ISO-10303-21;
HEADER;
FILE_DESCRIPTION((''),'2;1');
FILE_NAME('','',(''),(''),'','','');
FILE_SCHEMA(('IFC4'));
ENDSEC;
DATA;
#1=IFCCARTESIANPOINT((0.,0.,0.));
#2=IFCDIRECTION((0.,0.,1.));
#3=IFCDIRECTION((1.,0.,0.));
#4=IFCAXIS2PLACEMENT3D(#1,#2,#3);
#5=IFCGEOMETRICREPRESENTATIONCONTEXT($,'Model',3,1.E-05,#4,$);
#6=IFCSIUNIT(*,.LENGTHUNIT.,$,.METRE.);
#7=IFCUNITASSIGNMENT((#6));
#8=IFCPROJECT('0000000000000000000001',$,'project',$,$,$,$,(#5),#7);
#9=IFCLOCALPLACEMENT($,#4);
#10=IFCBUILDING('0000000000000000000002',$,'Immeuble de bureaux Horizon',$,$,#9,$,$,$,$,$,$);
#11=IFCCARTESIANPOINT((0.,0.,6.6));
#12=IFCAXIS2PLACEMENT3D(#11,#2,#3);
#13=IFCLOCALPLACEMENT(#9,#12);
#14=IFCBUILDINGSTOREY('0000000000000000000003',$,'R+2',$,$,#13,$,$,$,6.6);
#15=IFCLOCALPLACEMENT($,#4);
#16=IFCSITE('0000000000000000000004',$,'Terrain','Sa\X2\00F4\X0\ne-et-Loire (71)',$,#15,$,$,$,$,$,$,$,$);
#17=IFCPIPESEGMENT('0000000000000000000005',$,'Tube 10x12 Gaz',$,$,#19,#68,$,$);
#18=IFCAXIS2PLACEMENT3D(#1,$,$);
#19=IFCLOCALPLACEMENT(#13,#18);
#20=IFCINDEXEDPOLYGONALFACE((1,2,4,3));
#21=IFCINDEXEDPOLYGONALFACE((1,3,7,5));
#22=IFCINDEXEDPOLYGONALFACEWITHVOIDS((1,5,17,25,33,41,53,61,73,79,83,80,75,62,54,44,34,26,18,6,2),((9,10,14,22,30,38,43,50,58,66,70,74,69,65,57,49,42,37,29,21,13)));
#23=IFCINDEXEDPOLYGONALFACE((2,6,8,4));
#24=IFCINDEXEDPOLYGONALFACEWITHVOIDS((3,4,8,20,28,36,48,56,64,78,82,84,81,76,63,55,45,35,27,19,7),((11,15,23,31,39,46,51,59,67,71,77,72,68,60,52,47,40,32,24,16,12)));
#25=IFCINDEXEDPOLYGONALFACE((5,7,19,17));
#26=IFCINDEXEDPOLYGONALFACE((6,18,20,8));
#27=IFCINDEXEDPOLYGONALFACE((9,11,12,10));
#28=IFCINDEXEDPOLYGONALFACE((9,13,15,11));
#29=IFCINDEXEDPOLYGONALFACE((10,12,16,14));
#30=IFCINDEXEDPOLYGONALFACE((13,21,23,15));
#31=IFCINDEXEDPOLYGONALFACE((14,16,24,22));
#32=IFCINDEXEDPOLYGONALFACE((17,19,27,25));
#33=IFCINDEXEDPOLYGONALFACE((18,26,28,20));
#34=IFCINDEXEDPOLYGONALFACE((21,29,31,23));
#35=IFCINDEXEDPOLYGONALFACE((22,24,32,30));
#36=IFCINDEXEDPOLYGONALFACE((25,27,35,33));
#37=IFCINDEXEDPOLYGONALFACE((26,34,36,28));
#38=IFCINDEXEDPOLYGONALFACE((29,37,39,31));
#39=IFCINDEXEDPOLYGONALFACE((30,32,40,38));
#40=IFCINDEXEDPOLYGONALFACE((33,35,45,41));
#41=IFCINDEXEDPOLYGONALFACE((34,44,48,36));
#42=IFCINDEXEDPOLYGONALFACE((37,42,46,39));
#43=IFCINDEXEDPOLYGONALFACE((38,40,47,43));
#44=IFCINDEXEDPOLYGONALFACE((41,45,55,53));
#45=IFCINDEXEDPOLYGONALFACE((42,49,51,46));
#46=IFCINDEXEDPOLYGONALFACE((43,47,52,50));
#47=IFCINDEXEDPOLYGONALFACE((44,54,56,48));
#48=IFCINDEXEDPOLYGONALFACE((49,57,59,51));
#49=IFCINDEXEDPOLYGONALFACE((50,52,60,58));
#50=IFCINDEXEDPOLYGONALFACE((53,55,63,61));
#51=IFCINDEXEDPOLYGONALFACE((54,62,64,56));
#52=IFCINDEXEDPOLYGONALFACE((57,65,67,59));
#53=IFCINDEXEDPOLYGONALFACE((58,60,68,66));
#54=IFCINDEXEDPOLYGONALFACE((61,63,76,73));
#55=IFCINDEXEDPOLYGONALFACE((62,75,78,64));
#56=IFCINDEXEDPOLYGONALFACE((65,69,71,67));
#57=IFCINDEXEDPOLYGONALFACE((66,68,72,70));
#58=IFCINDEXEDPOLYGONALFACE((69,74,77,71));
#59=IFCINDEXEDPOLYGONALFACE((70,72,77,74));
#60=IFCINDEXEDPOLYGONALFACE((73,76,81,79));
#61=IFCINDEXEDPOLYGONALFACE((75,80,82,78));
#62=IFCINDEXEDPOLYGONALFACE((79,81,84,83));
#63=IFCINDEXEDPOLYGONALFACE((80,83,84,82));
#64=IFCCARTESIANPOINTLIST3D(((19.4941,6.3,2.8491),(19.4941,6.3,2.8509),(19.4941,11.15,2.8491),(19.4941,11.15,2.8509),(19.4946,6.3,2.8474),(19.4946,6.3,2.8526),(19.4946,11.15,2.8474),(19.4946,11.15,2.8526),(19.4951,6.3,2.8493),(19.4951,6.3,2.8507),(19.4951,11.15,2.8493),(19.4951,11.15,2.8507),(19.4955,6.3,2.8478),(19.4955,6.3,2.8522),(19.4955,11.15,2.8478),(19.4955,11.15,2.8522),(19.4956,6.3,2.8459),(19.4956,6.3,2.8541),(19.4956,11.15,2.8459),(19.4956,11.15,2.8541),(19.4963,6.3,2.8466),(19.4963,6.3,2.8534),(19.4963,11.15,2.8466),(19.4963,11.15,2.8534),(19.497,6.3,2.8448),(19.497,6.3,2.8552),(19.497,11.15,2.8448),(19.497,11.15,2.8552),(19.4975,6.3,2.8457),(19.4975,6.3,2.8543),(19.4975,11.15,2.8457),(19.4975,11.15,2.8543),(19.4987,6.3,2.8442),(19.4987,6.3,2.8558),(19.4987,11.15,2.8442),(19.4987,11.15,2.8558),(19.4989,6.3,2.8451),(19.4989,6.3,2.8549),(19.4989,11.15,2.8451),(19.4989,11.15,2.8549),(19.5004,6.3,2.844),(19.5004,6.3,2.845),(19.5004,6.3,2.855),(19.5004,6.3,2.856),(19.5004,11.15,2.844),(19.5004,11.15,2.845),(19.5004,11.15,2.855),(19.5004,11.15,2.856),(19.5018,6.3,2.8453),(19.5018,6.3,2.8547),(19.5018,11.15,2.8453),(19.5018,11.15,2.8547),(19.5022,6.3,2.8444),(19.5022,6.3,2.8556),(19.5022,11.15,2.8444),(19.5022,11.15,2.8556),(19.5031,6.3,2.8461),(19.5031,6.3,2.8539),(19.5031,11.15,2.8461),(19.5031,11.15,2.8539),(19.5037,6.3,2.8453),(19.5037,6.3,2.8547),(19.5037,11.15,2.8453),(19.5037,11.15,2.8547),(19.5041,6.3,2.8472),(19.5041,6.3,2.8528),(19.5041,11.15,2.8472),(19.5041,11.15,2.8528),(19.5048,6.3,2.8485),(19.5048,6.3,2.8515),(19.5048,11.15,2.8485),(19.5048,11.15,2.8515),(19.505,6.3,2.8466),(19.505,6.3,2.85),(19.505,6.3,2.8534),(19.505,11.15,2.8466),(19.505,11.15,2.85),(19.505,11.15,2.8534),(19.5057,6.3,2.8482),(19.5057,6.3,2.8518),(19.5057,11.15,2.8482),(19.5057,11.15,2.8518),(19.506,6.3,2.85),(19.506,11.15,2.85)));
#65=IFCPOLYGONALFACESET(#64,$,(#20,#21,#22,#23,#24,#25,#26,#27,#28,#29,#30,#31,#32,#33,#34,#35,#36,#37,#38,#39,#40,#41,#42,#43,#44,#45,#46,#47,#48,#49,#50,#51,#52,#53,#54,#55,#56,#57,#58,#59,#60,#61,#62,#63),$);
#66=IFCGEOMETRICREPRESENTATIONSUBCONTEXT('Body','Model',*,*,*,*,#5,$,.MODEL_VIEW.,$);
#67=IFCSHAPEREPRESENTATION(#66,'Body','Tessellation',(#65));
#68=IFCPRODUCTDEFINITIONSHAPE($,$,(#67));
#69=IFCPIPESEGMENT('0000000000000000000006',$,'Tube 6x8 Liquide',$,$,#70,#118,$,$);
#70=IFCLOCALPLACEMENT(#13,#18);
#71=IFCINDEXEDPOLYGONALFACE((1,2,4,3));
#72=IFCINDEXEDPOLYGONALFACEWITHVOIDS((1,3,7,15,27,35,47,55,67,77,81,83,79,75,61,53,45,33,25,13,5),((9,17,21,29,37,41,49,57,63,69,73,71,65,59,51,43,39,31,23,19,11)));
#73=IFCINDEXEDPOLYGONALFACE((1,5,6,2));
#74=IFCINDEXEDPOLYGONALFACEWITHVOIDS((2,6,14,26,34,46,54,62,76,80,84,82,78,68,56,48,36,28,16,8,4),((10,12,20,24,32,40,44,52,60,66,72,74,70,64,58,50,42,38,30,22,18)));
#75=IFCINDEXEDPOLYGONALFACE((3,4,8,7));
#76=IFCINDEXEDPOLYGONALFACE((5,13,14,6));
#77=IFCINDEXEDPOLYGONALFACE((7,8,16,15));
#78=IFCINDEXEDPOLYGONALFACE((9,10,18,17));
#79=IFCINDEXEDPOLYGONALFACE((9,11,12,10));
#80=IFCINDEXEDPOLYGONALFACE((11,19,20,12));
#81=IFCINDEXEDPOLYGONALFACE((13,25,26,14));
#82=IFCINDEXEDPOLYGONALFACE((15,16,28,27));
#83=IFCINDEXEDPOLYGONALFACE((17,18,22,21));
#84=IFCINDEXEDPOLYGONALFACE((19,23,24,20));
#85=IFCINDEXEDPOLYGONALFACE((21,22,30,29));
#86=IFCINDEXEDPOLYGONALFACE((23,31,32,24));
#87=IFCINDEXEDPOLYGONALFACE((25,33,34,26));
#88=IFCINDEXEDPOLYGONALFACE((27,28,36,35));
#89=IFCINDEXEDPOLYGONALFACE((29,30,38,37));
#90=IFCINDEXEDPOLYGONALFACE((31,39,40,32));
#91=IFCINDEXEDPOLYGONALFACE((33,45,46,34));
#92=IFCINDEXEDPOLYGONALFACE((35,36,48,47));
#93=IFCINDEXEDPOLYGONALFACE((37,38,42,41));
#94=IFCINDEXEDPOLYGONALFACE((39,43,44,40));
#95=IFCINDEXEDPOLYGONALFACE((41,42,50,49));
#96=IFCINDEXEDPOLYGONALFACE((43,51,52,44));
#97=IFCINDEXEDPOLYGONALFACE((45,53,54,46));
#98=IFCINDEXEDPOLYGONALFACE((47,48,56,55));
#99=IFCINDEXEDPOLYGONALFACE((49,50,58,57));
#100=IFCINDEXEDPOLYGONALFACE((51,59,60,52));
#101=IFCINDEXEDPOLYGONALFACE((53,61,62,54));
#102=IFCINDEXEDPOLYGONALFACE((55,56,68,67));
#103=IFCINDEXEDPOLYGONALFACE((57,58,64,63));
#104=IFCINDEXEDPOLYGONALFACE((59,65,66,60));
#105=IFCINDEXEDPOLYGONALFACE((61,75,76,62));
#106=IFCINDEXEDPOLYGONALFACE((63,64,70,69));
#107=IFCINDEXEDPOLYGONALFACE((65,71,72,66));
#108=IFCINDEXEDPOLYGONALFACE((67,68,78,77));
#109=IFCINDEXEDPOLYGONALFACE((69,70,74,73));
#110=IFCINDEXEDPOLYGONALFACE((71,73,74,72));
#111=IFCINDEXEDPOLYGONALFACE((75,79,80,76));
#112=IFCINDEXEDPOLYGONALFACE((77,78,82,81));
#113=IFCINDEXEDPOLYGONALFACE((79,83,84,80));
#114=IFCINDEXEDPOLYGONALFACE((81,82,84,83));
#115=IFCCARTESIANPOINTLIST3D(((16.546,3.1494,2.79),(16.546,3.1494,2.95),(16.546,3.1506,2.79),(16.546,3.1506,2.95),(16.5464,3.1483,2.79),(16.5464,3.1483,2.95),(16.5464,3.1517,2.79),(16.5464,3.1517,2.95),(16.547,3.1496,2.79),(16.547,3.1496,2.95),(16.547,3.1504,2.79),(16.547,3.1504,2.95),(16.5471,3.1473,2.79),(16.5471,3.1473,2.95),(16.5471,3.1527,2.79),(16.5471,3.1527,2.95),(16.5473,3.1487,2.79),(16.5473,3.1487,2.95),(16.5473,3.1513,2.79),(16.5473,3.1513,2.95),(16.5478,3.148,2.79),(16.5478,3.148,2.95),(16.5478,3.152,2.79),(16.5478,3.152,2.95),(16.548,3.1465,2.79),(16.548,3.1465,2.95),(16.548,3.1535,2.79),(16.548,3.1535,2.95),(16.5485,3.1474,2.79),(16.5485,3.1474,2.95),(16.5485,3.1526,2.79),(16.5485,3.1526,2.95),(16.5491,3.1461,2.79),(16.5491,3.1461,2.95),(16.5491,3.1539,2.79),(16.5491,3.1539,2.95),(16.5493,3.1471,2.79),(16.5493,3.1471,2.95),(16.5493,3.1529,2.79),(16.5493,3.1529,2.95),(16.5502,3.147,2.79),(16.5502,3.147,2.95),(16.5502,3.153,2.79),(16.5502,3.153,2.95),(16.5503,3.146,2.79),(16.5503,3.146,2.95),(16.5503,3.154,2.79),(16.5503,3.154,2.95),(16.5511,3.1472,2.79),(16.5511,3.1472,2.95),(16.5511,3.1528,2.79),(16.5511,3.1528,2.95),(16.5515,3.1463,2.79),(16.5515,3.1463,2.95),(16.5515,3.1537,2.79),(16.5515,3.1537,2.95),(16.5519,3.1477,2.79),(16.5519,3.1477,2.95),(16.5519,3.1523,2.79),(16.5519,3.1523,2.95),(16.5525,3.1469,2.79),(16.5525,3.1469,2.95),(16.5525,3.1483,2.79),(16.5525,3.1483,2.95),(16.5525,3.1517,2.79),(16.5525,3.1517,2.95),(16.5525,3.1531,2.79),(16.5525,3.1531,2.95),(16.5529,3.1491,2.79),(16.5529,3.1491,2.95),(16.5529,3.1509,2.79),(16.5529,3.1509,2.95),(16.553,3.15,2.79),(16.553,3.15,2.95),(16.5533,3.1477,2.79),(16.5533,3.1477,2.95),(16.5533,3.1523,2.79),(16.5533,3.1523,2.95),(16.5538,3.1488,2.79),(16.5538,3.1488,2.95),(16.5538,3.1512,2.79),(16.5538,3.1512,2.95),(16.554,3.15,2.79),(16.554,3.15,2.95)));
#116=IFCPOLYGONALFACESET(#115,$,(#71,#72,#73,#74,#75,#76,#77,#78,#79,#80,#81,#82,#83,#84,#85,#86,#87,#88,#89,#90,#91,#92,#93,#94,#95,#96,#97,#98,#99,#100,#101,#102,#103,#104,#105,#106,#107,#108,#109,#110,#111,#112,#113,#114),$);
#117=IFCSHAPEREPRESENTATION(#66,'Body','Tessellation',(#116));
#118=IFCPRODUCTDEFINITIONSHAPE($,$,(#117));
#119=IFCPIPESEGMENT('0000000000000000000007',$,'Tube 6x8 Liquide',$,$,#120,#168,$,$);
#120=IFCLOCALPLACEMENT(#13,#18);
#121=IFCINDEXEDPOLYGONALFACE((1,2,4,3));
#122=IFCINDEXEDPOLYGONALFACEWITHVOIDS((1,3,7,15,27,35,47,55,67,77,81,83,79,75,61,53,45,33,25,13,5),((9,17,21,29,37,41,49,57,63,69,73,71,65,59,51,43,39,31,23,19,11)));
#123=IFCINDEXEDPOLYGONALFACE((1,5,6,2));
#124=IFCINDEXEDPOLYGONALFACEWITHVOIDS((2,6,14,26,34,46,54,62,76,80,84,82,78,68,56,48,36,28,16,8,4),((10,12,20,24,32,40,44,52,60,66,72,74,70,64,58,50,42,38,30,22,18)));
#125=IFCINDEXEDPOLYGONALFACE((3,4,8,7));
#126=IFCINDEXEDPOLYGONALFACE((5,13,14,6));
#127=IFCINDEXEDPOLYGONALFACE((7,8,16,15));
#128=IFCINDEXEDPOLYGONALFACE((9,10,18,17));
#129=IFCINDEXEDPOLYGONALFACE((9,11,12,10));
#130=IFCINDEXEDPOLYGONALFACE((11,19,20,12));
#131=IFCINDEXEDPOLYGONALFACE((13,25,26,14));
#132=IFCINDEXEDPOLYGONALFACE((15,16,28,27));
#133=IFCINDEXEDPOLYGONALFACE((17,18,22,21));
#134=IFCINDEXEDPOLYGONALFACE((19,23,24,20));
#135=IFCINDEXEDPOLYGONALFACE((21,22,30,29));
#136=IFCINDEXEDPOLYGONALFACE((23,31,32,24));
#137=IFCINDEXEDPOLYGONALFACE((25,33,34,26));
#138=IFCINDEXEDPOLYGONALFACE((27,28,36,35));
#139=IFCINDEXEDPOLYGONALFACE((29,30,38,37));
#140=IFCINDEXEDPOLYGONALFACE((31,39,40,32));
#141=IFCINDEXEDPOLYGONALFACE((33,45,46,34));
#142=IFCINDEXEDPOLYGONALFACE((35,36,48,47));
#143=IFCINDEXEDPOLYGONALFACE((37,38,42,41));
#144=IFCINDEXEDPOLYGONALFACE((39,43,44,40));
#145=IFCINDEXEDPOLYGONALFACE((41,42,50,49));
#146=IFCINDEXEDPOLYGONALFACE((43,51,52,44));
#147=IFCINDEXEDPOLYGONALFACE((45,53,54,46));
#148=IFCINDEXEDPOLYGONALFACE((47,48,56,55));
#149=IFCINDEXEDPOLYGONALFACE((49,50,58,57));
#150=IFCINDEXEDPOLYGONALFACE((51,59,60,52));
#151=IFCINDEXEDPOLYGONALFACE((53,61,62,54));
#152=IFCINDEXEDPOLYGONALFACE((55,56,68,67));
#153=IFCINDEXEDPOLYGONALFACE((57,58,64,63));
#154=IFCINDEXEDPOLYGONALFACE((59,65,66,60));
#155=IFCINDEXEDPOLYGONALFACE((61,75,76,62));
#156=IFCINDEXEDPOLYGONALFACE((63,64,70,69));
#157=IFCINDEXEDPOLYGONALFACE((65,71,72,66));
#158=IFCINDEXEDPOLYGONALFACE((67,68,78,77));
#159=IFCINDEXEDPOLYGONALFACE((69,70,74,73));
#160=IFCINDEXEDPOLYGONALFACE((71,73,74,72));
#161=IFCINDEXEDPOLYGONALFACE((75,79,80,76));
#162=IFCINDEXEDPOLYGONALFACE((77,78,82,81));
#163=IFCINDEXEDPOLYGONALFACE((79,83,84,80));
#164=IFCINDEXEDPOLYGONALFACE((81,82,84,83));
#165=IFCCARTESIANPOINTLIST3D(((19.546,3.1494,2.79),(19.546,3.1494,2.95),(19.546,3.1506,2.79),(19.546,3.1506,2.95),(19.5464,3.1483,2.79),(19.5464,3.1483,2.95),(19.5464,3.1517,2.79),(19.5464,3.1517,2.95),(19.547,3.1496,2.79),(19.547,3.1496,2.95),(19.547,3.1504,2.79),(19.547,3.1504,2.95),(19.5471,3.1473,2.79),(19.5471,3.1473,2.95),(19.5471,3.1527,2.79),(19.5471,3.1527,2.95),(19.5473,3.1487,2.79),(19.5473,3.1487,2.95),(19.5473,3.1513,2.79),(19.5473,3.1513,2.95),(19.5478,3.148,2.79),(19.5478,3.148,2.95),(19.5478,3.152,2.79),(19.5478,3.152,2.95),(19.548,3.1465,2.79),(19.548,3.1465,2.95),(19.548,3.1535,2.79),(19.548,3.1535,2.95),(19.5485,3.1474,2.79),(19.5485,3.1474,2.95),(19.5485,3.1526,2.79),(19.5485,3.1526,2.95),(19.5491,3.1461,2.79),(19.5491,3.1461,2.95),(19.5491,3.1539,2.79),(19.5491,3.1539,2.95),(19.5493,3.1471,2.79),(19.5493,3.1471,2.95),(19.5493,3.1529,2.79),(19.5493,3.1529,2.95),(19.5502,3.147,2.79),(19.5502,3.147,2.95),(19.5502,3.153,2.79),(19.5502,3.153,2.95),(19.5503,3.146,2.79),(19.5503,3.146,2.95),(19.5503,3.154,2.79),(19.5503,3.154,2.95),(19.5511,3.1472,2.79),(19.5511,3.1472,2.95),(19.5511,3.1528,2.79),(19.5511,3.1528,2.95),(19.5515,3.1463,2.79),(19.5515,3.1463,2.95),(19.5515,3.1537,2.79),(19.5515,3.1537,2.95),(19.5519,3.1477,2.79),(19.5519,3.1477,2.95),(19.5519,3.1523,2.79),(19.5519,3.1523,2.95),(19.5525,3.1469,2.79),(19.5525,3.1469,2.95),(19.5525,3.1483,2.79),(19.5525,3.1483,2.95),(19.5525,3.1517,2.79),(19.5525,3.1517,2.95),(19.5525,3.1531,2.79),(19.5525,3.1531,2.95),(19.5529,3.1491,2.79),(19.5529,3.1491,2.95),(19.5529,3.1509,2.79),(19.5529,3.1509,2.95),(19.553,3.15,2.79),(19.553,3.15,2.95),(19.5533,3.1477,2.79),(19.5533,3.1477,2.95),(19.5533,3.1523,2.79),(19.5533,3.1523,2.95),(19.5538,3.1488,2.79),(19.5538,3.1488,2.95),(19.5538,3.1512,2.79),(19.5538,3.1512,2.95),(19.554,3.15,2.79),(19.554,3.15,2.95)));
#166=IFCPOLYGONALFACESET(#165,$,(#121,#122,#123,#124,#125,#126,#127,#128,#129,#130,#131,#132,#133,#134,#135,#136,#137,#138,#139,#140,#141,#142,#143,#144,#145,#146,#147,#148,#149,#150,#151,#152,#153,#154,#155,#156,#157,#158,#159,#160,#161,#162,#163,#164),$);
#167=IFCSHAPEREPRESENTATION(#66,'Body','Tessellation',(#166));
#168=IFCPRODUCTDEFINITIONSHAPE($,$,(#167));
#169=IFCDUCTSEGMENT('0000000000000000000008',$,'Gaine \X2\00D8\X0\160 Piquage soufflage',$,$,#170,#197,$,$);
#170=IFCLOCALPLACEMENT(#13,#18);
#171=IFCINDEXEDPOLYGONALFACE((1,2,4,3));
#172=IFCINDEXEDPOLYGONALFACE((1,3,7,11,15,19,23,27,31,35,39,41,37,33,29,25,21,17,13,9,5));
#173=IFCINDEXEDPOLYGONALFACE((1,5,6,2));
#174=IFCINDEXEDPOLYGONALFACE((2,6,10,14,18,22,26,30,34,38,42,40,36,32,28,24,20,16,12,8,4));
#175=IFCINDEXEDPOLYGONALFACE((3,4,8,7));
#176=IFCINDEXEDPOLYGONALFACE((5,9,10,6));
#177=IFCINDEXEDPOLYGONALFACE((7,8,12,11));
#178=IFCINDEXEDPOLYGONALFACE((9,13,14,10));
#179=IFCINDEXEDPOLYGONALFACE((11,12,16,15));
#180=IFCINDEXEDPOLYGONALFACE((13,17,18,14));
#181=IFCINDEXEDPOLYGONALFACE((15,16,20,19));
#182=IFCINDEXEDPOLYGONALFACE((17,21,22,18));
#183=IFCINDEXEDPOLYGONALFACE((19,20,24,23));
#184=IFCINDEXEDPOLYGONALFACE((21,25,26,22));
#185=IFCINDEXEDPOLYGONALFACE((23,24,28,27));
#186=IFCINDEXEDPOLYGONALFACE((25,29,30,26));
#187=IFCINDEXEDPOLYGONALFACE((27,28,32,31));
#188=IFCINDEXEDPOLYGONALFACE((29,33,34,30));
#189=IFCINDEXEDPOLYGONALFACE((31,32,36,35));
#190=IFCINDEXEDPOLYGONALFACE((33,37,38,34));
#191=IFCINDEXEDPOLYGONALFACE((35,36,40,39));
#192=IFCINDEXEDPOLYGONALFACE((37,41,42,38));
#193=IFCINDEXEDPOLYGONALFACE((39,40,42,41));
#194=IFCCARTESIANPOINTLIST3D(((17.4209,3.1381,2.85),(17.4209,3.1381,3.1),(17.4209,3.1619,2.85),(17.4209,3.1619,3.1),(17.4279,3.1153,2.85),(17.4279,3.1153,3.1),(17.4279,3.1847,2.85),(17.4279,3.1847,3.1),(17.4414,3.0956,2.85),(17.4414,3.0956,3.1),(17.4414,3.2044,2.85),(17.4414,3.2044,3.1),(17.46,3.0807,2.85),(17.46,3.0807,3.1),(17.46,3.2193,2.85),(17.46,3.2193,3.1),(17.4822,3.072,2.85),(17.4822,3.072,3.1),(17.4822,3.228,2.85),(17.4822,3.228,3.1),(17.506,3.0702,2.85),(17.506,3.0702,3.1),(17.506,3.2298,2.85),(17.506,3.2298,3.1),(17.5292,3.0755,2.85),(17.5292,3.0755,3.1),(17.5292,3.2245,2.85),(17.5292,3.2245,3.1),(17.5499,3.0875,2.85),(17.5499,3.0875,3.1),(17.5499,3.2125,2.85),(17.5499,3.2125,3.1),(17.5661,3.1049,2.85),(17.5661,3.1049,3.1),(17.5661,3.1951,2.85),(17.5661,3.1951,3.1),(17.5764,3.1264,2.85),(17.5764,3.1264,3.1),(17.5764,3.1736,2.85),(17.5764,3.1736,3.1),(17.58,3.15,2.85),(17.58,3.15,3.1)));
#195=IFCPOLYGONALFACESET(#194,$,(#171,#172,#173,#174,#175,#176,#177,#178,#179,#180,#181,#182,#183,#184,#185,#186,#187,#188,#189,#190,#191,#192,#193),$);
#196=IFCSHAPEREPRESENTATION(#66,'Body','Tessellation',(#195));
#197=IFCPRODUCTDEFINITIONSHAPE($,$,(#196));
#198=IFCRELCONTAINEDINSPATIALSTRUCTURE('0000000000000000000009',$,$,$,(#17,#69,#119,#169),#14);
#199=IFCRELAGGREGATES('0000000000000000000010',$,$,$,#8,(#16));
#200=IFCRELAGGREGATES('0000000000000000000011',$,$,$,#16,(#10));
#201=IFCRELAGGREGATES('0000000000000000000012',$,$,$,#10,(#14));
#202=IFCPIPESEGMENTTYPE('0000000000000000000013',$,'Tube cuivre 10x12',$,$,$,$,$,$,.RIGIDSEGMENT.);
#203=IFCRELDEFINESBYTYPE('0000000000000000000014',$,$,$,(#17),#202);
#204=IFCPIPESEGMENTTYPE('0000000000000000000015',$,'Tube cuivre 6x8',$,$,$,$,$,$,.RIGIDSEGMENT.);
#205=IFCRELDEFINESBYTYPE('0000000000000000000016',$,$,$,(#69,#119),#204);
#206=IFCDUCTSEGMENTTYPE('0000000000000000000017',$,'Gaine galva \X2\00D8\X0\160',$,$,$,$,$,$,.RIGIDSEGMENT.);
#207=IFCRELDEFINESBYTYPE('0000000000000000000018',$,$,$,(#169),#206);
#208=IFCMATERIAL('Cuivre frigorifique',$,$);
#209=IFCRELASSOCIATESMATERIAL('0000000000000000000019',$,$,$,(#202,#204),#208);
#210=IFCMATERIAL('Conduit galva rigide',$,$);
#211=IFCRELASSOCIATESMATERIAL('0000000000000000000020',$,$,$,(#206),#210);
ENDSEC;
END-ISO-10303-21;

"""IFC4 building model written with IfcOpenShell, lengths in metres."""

from ifc_helpers import new_model, si_unit, frame, origin_with_axes, place, context, subcontext, project, spatial, circle, hollow_circle, extrude, material, type_object, element, save


model = new_model("IFC4")

# Units and contexts
model_context = context("Model", 3, precision=1e-05, world=origin_with_axes())
body_context = subcontext(model_context, "Body", "Model", "MODEL_VIEW")
ifc_project = project(units=[si_unit("LENGTHUNIT", "METRE")], contexts=[model_context])

# Site, building, storey
site_placement = place(None, origin_with_axes())
site = spatial("IfcSite", under=ifc_project, at=site_placement, Name="Terrain", Description="Saône-et-Loire (71)")
building_placement = place(None, origin_with_axes())
building = spatial("IfcBuilding", under=site, at=building_placement, Name="Immeuble de bureaux Horizon")
storey_placement = place(building_placement, frame((0.0, 0.0, 6.6), z_axis=(0.0, 0.0, 1.0), x_axis=(1.0, 0.0, 0.0)))
storey = spatial("IfcBuildingStorey", under=building, at=storey_placement, Name="R+2", Elevation=6.6)

# Pipe segments
ifc_material_1 = material(Name="Cuivre frigorifique")
pipe_segment_type_1 = type_object("IfcPipeSegmentType", Name="Tube cuivre 10x12", PredefinedType="RIGIDSEGMENT", material=ifc_material_1)
for number, where, z_axis, x_axis, name in (
    (1, (19.5, 6.3, 2.85), (0.0, 1.0, 0.0), (1.0, 0.0, 0.0), "Tube 10x12 Gaz"),
):
    element("IfcPipeSegment", number, at=place(storey_placement, frame(where, z_axis=z_axis, x_axis=x_axis)), inside=storey, type_object=pipe_segment_type_1, Name=name, context=body_context, shape_type="SweptSolid", body=[
        extrude(hollow_circle(Radius=0.006, WallThickness=0.001), origin_with_axes(), (0.0, 0.0, 1.0), 4.85),
    ])
pipe_segment_type_2 = type_object("IfcPipeSegmentType", Name="Tube cuivre 6x8", PredefinedType="RIGIDSEGMENT", material=ifc_material_1)
for number, where, z_axis, x_axis, name in (
    (2, (16.55, 3.15, 2.79), (0.0, 0.0, 1.0), (1.0, 0.0, 0.0), "Tube 6x8 Liquide"),
    (3, (19.55, 3.15, 2.79), (0.0, 0.0, 1.0), (1.0, 0.0, 0.0), "Tube 6x8 Liquide"),
):
    element("IfcPipeSegment", number, at=place(storey_placement, frame(where, z_axis=z_axis, x_axis=x_axis)), inside=storey, type_object=pipe_segment_type_2, Name=name, context=body_context, shape_type="SweptSolid", body=[
        extrude(hollow_circle(Radius=0.004, WallThickness=0.001), origin_with_axes(), (0.0, 0.0, 1.0), 0.16),
    ])

# Duct segment
ifc_material_2 = material(Name="Conduit galva rigide")
duct_segment_type = type_object("IfcDuctSegmentType", Name="Gaine galva Ø160", PredefinedType="RIGIDSEGMENT", material=ifc_material_2)
duct_segment_1_placement = place(storey_placement, frame((17.5, 3.15, 3.1), z_axis=(0.0, 0.0, -1.0), x_axis=(1.0, 0.0, 0.0)))
element("IfcDuctSegment", 4, at=duct_segment_1_placement, inside=storey, type_object=duct_segment_type, Name="Gaine Ø160 Piquage soufflage", context=body_context, shape_type="SweptSolid", body=[
    extrude(circle(Radius=0.08), origin_with_axes(), (0.0, 0.0, 1.0), 0.25),
])

save(model, "model.ifc")
